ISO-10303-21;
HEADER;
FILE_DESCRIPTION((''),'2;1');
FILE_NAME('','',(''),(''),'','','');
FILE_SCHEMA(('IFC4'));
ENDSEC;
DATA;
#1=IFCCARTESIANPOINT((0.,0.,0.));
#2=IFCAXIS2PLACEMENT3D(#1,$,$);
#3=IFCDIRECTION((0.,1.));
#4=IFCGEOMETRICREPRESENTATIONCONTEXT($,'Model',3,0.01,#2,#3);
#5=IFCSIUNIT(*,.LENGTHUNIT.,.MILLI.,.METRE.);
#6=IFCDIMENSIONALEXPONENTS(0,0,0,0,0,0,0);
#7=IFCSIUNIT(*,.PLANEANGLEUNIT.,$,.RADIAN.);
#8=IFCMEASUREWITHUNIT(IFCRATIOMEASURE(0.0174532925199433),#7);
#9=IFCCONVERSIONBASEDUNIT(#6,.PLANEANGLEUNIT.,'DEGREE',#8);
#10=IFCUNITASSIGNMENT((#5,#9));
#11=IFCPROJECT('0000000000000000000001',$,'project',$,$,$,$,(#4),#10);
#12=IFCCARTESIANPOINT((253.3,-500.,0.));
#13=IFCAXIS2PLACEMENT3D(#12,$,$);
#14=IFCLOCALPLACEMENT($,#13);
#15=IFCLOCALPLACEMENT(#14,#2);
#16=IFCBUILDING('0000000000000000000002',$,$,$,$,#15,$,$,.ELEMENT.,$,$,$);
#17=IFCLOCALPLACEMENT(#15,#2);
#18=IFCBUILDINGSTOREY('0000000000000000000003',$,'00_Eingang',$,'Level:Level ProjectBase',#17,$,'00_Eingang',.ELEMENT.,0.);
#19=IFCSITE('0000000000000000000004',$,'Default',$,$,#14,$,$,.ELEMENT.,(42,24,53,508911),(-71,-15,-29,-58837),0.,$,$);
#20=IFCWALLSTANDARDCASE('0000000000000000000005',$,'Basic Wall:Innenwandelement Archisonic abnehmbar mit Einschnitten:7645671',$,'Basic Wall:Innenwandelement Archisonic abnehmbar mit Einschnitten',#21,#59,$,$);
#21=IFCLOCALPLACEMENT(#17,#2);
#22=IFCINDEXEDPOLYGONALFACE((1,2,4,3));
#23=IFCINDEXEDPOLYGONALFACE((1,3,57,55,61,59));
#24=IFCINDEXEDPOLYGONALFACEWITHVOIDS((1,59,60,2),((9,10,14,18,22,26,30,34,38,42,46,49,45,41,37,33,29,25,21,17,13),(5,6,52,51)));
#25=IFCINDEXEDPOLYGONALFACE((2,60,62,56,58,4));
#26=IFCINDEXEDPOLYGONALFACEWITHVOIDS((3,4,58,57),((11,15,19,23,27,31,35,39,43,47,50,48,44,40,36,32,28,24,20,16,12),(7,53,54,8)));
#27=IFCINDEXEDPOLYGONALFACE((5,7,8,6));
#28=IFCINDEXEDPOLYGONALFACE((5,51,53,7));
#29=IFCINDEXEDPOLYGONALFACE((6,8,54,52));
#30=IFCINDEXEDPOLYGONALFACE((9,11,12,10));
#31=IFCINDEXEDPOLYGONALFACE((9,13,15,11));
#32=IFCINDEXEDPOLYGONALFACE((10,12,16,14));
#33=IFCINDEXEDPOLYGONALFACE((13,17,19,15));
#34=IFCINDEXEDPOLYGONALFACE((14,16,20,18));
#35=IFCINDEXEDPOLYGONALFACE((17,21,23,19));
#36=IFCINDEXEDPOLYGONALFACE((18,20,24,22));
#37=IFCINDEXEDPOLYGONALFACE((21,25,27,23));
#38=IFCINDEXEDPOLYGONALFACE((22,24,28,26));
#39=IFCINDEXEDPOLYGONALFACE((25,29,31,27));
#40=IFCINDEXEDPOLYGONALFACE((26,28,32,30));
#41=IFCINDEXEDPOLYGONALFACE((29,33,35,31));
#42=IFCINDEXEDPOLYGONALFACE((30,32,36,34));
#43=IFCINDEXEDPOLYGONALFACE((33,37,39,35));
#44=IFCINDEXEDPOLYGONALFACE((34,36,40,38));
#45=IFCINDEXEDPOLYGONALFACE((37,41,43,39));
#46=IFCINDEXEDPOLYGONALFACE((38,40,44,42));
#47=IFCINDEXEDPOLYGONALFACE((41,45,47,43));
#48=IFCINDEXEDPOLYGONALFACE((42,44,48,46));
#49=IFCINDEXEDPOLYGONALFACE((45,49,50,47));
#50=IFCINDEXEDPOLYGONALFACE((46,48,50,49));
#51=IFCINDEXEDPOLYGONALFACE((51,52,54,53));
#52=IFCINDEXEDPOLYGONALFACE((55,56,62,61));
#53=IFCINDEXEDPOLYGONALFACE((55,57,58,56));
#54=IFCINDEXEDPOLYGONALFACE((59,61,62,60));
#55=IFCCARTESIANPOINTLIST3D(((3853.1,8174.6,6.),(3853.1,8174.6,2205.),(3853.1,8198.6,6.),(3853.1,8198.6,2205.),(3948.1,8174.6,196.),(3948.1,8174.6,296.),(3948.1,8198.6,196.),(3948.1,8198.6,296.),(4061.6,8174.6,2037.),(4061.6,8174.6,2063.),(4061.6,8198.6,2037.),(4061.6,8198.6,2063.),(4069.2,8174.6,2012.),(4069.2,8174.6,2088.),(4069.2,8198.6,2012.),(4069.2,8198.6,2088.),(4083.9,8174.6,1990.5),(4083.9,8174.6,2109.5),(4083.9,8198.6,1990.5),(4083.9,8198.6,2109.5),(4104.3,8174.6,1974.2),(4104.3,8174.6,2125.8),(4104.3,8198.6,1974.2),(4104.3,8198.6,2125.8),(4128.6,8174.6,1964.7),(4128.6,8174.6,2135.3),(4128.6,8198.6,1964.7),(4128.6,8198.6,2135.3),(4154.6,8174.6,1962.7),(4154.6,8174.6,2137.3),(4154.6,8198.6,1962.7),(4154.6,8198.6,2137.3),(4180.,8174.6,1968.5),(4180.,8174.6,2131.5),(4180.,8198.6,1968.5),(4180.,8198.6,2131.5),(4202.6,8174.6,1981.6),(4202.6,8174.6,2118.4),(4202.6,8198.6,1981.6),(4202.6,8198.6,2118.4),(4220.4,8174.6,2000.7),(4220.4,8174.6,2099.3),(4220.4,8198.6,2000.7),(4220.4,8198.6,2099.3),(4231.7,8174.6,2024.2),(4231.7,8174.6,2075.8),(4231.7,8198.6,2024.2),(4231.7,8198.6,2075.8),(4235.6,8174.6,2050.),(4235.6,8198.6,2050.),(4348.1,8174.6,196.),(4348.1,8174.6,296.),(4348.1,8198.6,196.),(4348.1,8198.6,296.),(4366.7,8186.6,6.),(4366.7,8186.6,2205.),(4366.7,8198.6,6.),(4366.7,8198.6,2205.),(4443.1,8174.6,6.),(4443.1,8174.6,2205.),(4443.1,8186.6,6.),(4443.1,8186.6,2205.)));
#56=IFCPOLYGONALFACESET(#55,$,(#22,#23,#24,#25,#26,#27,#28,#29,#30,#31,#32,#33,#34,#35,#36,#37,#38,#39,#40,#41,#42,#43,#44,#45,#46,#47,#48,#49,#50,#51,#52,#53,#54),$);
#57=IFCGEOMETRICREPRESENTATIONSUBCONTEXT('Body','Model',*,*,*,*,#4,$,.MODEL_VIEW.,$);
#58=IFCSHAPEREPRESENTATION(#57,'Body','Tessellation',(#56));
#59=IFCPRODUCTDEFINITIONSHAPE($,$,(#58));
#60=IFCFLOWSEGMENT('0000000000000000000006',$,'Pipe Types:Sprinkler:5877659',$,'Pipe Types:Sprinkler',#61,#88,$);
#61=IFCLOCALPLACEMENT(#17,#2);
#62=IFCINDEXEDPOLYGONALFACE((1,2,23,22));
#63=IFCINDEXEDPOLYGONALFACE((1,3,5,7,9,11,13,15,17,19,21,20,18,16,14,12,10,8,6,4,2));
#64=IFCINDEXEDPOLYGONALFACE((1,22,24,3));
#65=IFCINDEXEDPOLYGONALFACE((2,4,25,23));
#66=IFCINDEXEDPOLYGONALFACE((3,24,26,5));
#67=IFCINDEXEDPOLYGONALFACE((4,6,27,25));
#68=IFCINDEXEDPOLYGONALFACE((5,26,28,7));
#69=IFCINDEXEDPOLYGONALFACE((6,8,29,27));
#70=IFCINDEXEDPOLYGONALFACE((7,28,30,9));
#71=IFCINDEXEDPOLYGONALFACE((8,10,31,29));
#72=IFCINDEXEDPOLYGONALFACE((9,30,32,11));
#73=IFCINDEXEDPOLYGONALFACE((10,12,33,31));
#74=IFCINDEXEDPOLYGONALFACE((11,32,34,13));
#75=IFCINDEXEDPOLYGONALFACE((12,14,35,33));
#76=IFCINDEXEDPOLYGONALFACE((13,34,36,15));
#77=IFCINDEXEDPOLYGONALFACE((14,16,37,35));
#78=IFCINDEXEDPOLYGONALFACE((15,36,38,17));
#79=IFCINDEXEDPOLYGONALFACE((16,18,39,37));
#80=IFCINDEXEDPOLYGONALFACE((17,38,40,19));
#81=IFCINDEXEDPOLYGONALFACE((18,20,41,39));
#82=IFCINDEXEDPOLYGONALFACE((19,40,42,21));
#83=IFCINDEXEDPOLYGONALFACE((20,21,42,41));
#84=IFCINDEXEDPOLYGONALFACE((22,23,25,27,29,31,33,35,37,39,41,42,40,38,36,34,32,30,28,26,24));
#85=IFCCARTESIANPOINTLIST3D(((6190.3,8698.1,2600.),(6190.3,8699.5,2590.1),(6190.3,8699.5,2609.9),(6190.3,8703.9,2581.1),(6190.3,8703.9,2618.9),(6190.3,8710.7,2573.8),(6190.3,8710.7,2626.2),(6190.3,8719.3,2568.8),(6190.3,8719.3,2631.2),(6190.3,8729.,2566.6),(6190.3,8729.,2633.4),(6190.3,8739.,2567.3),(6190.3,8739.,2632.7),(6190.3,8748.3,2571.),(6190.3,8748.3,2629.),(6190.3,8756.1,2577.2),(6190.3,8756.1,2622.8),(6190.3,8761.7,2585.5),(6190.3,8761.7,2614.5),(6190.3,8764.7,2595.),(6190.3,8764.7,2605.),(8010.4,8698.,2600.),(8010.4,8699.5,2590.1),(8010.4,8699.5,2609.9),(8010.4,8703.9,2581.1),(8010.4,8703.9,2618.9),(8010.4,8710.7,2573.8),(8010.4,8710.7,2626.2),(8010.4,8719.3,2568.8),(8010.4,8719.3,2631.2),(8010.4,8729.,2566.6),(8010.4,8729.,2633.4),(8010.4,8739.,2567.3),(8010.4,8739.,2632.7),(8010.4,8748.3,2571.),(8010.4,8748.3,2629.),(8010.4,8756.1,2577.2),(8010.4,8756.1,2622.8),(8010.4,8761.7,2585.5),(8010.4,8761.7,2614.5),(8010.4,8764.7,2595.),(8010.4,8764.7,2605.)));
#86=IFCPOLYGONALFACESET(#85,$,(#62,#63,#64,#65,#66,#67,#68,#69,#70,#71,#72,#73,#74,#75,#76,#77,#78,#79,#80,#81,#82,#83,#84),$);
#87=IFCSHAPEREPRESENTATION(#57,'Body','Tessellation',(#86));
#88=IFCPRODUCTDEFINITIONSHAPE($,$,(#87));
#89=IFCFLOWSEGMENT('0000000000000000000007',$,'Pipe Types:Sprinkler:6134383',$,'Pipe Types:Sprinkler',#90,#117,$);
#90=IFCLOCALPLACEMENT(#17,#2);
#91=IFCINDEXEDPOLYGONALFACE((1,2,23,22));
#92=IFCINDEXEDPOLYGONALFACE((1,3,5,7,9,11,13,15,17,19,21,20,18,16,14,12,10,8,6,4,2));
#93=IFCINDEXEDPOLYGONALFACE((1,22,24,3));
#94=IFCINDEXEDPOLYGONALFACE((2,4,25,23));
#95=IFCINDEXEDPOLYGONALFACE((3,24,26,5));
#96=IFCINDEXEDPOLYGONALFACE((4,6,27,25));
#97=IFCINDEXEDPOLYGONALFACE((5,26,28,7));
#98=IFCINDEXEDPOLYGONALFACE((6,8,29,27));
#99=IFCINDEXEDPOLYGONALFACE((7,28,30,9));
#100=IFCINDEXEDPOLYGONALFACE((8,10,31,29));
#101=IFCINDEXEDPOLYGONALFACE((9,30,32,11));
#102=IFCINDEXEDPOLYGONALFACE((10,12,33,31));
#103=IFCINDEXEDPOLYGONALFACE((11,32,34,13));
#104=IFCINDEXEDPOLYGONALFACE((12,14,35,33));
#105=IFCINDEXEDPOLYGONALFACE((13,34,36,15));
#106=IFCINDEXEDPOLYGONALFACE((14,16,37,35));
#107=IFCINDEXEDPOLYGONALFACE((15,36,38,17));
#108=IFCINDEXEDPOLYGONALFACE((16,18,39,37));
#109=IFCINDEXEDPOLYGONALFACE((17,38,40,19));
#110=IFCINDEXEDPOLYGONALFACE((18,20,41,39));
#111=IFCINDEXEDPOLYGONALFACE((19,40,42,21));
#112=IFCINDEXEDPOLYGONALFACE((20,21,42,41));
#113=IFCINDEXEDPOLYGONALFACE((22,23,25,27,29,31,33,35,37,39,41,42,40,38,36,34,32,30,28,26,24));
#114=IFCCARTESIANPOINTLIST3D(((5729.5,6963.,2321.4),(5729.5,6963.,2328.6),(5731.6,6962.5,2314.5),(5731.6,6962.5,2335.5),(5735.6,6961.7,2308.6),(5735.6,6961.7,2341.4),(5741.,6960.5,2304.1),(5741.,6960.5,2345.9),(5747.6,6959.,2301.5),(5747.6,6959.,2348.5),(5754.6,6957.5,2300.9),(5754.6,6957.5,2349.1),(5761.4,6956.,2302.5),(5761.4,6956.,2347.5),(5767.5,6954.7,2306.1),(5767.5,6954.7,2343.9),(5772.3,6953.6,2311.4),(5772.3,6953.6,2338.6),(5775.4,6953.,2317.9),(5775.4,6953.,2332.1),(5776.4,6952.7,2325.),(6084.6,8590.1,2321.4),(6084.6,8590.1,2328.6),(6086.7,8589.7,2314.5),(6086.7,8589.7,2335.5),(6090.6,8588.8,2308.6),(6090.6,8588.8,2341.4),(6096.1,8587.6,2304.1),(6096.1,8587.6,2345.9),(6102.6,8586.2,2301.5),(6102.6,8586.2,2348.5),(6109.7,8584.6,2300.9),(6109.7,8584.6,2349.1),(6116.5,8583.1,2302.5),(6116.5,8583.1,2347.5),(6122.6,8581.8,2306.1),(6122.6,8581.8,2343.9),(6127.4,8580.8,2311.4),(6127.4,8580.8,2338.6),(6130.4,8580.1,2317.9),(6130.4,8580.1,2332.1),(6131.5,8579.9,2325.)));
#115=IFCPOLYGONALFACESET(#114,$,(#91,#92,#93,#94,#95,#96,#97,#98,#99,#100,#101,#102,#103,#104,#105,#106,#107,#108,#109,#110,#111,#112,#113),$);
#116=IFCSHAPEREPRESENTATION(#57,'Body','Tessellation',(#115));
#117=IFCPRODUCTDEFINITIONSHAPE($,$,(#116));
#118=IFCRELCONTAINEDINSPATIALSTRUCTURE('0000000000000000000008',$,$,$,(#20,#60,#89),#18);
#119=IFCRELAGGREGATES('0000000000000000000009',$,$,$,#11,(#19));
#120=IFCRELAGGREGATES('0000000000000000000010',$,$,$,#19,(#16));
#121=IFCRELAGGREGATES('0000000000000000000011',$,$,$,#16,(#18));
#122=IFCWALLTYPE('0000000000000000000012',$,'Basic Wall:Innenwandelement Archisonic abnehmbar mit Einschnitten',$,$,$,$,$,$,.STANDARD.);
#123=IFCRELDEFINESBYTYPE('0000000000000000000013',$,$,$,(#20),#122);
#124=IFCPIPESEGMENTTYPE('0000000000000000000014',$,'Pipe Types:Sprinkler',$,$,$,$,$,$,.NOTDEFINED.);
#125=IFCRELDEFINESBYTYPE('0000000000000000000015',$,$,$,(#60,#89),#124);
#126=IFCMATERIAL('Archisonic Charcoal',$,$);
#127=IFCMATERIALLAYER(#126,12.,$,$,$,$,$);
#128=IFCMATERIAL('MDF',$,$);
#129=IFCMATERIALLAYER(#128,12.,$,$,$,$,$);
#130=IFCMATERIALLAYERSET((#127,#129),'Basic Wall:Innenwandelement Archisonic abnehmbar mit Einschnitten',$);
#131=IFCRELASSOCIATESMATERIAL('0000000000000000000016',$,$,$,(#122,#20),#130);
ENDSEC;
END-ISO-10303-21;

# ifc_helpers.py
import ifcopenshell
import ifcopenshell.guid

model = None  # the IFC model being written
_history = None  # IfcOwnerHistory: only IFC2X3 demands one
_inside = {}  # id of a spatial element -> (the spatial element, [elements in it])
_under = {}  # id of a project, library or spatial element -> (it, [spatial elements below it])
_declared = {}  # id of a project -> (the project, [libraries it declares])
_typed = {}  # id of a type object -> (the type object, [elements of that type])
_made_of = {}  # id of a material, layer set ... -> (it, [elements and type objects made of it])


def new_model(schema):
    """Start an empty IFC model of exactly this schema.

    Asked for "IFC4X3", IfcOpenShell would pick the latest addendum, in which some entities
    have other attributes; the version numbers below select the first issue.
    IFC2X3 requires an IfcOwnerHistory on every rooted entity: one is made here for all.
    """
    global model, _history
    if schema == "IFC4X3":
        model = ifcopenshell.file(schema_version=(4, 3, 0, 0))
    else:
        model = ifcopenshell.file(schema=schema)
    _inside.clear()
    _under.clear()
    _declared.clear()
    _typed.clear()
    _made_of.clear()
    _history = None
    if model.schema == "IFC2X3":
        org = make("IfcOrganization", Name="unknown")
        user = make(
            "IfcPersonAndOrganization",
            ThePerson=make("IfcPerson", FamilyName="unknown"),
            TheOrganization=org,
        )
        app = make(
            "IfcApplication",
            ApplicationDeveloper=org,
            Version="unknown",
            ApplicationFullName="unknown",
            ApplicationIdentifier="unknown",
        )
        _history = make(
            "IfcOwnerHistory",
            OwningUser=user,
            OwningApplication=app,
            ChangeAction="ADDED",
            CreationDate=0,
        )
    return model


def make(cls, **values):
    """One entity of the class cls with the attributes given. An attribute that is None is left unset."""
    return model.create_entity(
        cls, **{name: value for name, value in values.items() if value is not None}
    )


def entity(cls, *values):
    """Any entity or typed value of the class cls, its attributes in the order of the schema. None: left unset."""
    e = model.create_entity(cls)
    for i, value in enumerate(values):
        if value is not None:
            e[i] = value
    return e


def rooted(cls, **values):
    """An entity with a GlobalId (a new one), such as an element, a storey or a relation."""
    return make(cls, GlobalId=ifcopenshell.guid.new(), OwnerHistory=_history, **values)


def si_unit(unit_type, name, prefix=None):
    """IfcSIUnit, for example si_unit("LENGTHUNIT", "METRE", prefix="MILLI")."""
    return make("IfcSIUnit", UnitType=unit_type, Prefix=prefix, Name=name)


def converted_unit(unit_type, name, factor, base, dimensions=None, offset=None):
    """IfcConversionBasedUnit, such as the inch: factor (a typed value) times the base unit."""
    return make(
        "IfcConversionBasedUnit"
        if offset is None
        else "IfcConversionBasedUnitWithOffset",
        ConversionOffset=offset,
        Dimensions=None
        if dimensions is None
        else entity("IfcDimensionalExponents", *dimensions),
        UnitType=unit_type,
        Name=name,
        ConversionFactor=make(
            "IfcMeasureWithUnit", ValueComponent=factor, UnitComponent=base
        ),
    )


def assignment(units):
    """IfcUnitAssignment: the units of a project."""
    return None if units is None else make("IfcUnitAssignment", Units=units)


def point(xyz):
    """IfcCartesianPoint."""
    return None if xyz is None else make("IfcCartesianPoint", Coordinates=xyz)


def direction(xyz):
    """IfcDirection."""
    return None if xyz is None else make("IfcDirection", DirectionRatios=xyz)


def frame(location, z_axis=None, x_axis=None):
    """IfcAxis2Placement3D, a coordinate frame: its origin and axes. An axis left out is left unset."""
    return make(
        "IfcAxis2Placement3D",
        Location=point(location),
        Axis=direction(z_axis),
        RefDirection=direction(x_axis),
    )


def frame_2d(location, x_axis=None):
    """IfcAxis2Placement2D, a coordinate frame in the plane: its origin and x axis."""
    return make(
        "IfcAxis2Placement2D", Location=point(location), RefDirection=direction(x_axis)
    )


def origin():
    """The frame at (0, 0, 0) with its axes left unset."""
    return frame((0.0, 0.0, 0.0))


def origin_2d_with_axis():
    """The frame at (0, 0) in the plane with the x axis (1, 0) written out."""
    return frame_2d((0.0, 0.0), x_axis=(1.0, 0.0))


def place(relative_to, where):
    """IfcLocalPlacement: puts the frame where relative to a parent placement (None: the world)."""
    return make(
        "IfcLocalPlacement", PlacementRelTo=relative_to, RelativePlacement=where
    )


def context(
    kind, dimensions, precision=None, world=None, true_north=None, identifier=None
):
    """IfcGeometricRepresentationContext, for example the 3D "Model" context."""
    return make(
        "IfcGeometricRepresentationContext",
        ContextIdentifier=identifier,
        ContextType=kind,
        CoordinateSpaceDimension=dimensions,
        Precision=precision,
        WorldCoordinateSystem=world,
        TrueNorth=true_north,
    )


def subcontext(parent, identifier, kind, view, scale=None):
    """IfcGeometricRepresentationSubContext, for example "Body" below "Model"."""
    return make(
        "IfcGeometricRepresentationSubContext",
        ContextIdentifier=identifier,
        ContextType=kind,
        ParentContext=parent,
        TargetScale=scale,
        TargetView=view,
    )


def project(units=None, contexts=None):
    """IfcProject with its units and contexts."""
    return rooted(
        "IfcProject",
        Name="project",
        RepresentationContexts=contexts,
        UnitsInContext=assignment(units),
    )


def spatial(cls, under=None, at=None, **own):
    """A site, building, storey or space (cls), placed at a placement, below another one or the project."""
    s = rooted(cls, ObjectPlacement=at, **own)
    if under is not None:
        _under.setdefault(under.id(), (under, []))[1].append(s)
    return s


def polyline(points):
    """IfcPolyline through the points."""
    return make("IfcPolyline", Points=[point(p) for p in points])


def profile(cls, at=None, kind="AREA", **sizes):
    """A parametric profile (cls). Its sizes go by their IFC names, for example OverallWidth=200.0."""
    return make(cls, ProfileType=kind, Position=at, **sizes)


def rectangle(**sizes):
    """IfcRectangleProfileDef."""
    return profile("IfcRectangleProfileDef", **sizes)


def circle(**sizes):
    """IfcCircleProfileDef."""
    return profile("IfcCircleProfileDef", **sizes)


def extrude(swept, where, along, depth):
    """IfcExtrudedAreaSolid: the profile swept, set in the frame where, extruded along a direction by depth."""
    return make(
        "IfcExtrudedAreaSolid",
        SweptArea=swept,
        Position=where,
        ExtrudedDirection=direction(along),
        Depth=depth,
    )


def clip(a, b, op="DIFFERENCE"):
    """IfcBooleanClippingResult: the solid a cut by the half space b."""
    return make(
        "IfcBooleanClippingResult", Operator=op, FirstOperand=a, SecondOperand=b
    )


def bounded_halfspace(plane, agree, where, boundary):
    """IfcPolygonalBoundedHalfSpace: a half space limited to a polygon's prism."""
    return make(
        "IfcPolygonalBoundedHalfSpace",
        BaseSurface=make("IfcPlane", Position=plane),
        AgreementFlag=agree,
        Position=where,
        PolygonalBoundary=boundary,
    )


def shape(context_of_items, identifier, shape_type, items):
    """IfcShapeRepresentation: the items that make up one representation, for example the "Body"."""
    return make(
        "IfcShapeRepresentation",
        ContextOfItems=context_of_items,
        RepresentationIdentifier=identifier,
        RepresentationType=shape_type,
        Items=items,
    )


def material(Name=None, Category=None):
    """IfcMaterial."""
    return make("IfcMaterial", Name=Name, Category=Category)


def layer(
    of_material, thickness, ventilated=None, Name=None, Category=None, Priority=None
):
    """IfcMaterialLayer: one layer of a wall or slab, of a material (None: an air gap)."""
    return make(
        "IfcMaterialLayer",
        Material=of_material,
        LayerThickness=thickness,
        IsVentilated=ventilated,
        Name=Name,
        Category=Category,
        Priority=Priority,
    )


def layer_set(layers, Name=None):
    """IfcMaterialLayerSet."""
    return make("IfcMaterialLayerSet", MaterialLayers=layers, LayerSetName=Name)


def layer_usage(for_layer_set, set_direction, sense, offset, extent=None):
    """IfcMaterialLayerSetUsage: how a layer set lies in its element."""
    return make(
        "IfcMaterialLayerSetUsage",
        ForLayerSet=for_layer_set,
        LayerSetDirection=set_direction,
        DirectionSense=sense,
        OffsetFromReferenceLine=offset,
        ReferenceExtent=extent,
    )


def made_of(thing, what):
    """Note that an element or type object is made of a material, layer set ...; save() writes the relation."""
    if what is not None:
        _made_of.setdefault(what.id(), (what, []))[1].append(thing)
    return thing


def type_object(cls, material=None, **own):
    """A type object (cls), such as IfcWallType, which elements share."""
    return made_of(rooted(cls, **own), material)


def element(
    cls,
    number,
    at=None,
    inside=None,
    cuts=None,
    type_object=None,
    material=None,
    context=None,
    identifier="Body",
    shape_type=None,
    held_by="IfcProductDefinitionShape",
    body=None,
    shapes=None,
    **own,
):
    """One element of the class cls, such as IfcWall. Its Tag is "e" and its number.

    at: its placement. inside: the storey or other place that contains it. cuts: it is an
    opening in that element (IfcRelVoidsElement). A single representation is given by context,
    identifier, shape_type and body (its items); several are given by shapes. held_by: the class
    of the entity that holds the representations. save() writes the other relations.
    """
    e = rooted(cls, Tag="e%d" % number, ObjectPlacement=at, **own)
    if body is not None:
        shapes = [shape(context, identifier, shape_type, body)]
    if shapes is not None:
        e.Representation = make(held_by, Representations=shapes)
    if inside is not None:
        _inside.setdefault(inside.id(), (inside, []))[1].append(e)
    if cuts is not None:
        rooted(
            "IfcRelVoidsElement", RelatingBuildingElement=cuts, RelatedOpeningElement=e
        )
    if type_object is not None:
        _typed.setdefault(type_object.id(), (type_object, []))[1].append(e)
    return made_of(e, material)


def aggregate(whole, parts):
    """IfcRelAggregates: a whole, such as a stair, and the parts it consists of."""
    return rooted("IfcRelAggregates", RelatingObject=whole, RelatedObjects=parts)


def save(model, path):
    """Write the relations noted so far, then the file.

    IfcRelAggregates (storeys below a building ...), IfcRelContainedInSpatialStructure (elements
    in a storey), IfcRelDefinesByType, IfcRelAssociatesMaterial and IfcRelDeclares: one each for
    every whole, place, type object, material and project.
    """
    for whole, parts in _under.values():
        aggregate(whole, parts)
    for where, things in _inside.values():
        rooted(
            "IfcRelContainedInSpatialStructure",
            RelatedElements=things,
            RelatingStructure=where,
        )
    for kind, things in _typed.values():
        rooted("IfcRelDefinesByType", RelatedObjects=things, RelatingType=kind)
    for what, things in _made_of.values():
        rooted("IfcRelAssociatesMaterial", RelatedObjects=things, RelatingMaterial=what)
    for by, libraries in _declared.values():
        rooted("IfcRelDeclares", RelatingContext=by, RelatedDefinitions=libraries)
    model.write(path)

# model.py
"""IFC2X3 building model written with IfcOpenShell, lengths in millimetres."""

from ifc_helpers import new_model, entity, si_unit, converted_unit, direction, frame, frame_2d, origin, origin_2d_with_axis, place, context, subcontext, project, spatial, polyline, rectangle, circle, extrude, clip, bounded_halfspace, material, layer, layer_set, layer_usage, type_object, element, save


model = new_model("IFC2X3")

# Units and contexts
model_context = context("Model", 3, precision=0.01, world=origin(), true_north=direction((0.0, 1.0)))
body_context = subcontext(model_context, "Body", "Model", "MODEL_VIEW")
ifc_project = project(units=[si_unit("LENGTHUNIT", "METRE", prefix="MILLI"), converted_unit("PLANEANGLEUNIT", "DEGREE", entity("IfcRatioMeasure", 0.0174532925199433), si_unit("PLANEANGLEUNIT", "RADIAN"), dimensions=[0, 0, 0, 0, 0, 0, 0])], contexts=[model_context])

# Site, building, storey
site_placement = place(None, frame((253.3, -500.0, 0.0)))
site = spatial("IfcSite", under=ifc_project, at=site_placement, Name="Default", CompositionType="ELEMENT", RefLatitude=(42, 24, 53, 508911), RefLongitude=(-71, -15, -29, -58837), RefElevation=0.0)
building_placement = place(site_placement, origin())
building = spatial("IfcBuilding", under=site, at=building_placement, CompositionType="ELEMENT")
storey_placement = place(building_placement, origin())
storey = spatial("IfcBuildingStorey", under=building, at=storey_placement, Name="00_Eingang", ObjectType="Level:Level ProjectBase", LongName="00_Eingang", CompositionType="ELEMENT", Elevation=0.0)

# Shared definitions
ifc_material_1 = material(Name="Archisonic Charcoal")
ifc_material_2 = material(Name="MDF")

# Wall, openings
ifc_layer_1 = layer(ifc_material_1, 12.0)
ifc_layer_2 = layer(ifc_material_2, 12.0)
ifc_layer_set_1 = layer_set([ifc_layer_1, ifc_layer_2], Name="Basic Wall:Innenwandelement Archisonic abnehmbar mit Einschnitten")
wall_type_1 = type_object("IfcWallType", Name="Basic Wall:Innenwandelement Archisonic abnehmbar mit Einschnitten", PredefinedType="STANDARD", material=ifc_layer_set_1)
ifc_layer_usage_1 = layer_usage(ifc_layer_set_1, "AXIS2", "NEGATIVE", 12.0)
wall_1_placement = place(storey_placement, frame((4443.1, 8186.6, 6.0), z_axis=(0.0, 0.0, 1.0), x_axis=(-1.0, 0.0, 0.0)))
wall_1 = element("IfcWallStandardCase", 1, at=wall_1_placement, inside=storey, type_object=wall_type_1, material=ifc_layer_usage_1, Name="Basic Wall:Innenwandelement Archisonic abnehmbar mit Einschnitten:7645671", ObjectType="Basic Wall:Innenwandelement Archisonic abnehmbar mit Einschnitten", context=body_context, shape_type="Clipping", body=[
    clip(clip(extrude(rectangle(XDim=590.0, YDim=24.0, at=frame_2d((295.0, 0.0), x_axis=(-1.0, 0.0))), origin(), (0.0, 0.0, 1.0), 2199.0), bounded_halfspace(frame((76.4, 0.0, 0.0), z_axis=(0.0, 1.0, 0.0), x_axis=(-1.0, 0.0, 0.0)), True, frame((76.4, 0.0, 0.0), z_axis=(0.0, 1.0, 0.0), x_axis=(-1.0, 0.0, 0.0)), polyline([(0.0, 0.0), (76.4, 0.0), (76.4, 2199.0), (0.0, 2199.0), (0.0, 0.0)]))), bounded_halfspace(frame((76.4, 0.0, 2199.0), z_axis=(1.0, 0.0, 0.0), x_axis=(0.0, -1.0, 0.0)), True, frame((76.4, 0.0, 2199.0), z_axis=(1.0, 0.0, 0.0), x_axis=(0.0, -1.0, 0.0)), polyline([(0.0, 0.0), (12.0, 0.0), (12.0, 2199.0), (0.0, 2199.0), (0.0, 0.0)]))),
])
opening_1_placement = place(wall_1_placement, frame((384.1, 46.7, 1954.9)))
element("IfcOpeningElement", 2, at=opening_1_placement, cuts=wall_1, ObjectType="Opening", context=body_context, shape_type="SweptSolid", body=[
    extrude(circle(Radius=87.5, at=origin_2d_with_axis()), frame((-89.1, -336.7, 89.1), z_axis=(0.0, 1.0, 0.0), x_axis=(-1.0, 0.0, 0.0)), (0.0, 0.0, 1.0), 336.7),
])
opening_2_placement = place(wall_1_placement, frame((495.0, 70.0, 190.0)))
element("IfcOpeningElement", 3, at=opening_2_placement, cuts=wall_1, ObjectType="Opening", context=body_context, shape_type="SweptSolid", body=[
    extrude(rectangle(XDim=100.0, YDim=400.0, at=frame_2d((0.0, 0.0), x_axis=(0.0, 1.0))), frame((-200.0, -200.0, 50.0), z_axis=(0.0, 1.0, 0.0), x_axis=(-1.0, 0.0, 0.0)), (0.0, 0.0, 1.0), 200.0),
])

# Flow segments
pipe_segment_type = type_object("IfcPipeSegmentType", Name="Pipe Types:Sprinkler", PredefinedType="NOTDEFINED")
flow_segment_1_placement = place(storey_placement, frame((6190.3, 8696.5, 2564.9)))
element("IfcFlowSegment", 4, at=flow_segment_1_placement, inside=storey, type_object=pipe_segment_type, Name="Pipe Types:Sprinkler:5877659", ObjectType="Pipe Types:Sprinkler", context=body_context, shape_type="SweptSolid", body=[
    extrude(circle(Radius=33.5, at=origin_2d_with_axis()), frame((0.0, 35.1, 35.1), z_axis=(1.0, -0.000001, 0.0), x_axis=(-0.000001, -1.0, 0.0)), (0.0, 0.0, 1.0), 1820.1),
])
flow_segment_2_placement = place(storey_placement, frame((5727.7, 6951.2, 2299.3)))
element("IfcFlowSegment", 5, at=flow_segment_2_placement, inside=storey, type_object=pipe_segment_type, Name="Pipe Types:Sprinkler:6134383", ObjectType="Pipe Types:Sprinkler", context=body_context, shape_type="SweptSolid", body=[
    extrude(circle(Radius=24.1, at=frame_2d((0.0, 0.0), x_axis=(1.0, 0.0))), frame((25.2, 6.7, 25.7), z_axis=(0.213196, 0.977009, 0.0), x_axis=(0.977009, -0.213196, 0.0)), (0.0, 0.0, 1.0), 1665.4),
])

save(model, "model.ifc")
